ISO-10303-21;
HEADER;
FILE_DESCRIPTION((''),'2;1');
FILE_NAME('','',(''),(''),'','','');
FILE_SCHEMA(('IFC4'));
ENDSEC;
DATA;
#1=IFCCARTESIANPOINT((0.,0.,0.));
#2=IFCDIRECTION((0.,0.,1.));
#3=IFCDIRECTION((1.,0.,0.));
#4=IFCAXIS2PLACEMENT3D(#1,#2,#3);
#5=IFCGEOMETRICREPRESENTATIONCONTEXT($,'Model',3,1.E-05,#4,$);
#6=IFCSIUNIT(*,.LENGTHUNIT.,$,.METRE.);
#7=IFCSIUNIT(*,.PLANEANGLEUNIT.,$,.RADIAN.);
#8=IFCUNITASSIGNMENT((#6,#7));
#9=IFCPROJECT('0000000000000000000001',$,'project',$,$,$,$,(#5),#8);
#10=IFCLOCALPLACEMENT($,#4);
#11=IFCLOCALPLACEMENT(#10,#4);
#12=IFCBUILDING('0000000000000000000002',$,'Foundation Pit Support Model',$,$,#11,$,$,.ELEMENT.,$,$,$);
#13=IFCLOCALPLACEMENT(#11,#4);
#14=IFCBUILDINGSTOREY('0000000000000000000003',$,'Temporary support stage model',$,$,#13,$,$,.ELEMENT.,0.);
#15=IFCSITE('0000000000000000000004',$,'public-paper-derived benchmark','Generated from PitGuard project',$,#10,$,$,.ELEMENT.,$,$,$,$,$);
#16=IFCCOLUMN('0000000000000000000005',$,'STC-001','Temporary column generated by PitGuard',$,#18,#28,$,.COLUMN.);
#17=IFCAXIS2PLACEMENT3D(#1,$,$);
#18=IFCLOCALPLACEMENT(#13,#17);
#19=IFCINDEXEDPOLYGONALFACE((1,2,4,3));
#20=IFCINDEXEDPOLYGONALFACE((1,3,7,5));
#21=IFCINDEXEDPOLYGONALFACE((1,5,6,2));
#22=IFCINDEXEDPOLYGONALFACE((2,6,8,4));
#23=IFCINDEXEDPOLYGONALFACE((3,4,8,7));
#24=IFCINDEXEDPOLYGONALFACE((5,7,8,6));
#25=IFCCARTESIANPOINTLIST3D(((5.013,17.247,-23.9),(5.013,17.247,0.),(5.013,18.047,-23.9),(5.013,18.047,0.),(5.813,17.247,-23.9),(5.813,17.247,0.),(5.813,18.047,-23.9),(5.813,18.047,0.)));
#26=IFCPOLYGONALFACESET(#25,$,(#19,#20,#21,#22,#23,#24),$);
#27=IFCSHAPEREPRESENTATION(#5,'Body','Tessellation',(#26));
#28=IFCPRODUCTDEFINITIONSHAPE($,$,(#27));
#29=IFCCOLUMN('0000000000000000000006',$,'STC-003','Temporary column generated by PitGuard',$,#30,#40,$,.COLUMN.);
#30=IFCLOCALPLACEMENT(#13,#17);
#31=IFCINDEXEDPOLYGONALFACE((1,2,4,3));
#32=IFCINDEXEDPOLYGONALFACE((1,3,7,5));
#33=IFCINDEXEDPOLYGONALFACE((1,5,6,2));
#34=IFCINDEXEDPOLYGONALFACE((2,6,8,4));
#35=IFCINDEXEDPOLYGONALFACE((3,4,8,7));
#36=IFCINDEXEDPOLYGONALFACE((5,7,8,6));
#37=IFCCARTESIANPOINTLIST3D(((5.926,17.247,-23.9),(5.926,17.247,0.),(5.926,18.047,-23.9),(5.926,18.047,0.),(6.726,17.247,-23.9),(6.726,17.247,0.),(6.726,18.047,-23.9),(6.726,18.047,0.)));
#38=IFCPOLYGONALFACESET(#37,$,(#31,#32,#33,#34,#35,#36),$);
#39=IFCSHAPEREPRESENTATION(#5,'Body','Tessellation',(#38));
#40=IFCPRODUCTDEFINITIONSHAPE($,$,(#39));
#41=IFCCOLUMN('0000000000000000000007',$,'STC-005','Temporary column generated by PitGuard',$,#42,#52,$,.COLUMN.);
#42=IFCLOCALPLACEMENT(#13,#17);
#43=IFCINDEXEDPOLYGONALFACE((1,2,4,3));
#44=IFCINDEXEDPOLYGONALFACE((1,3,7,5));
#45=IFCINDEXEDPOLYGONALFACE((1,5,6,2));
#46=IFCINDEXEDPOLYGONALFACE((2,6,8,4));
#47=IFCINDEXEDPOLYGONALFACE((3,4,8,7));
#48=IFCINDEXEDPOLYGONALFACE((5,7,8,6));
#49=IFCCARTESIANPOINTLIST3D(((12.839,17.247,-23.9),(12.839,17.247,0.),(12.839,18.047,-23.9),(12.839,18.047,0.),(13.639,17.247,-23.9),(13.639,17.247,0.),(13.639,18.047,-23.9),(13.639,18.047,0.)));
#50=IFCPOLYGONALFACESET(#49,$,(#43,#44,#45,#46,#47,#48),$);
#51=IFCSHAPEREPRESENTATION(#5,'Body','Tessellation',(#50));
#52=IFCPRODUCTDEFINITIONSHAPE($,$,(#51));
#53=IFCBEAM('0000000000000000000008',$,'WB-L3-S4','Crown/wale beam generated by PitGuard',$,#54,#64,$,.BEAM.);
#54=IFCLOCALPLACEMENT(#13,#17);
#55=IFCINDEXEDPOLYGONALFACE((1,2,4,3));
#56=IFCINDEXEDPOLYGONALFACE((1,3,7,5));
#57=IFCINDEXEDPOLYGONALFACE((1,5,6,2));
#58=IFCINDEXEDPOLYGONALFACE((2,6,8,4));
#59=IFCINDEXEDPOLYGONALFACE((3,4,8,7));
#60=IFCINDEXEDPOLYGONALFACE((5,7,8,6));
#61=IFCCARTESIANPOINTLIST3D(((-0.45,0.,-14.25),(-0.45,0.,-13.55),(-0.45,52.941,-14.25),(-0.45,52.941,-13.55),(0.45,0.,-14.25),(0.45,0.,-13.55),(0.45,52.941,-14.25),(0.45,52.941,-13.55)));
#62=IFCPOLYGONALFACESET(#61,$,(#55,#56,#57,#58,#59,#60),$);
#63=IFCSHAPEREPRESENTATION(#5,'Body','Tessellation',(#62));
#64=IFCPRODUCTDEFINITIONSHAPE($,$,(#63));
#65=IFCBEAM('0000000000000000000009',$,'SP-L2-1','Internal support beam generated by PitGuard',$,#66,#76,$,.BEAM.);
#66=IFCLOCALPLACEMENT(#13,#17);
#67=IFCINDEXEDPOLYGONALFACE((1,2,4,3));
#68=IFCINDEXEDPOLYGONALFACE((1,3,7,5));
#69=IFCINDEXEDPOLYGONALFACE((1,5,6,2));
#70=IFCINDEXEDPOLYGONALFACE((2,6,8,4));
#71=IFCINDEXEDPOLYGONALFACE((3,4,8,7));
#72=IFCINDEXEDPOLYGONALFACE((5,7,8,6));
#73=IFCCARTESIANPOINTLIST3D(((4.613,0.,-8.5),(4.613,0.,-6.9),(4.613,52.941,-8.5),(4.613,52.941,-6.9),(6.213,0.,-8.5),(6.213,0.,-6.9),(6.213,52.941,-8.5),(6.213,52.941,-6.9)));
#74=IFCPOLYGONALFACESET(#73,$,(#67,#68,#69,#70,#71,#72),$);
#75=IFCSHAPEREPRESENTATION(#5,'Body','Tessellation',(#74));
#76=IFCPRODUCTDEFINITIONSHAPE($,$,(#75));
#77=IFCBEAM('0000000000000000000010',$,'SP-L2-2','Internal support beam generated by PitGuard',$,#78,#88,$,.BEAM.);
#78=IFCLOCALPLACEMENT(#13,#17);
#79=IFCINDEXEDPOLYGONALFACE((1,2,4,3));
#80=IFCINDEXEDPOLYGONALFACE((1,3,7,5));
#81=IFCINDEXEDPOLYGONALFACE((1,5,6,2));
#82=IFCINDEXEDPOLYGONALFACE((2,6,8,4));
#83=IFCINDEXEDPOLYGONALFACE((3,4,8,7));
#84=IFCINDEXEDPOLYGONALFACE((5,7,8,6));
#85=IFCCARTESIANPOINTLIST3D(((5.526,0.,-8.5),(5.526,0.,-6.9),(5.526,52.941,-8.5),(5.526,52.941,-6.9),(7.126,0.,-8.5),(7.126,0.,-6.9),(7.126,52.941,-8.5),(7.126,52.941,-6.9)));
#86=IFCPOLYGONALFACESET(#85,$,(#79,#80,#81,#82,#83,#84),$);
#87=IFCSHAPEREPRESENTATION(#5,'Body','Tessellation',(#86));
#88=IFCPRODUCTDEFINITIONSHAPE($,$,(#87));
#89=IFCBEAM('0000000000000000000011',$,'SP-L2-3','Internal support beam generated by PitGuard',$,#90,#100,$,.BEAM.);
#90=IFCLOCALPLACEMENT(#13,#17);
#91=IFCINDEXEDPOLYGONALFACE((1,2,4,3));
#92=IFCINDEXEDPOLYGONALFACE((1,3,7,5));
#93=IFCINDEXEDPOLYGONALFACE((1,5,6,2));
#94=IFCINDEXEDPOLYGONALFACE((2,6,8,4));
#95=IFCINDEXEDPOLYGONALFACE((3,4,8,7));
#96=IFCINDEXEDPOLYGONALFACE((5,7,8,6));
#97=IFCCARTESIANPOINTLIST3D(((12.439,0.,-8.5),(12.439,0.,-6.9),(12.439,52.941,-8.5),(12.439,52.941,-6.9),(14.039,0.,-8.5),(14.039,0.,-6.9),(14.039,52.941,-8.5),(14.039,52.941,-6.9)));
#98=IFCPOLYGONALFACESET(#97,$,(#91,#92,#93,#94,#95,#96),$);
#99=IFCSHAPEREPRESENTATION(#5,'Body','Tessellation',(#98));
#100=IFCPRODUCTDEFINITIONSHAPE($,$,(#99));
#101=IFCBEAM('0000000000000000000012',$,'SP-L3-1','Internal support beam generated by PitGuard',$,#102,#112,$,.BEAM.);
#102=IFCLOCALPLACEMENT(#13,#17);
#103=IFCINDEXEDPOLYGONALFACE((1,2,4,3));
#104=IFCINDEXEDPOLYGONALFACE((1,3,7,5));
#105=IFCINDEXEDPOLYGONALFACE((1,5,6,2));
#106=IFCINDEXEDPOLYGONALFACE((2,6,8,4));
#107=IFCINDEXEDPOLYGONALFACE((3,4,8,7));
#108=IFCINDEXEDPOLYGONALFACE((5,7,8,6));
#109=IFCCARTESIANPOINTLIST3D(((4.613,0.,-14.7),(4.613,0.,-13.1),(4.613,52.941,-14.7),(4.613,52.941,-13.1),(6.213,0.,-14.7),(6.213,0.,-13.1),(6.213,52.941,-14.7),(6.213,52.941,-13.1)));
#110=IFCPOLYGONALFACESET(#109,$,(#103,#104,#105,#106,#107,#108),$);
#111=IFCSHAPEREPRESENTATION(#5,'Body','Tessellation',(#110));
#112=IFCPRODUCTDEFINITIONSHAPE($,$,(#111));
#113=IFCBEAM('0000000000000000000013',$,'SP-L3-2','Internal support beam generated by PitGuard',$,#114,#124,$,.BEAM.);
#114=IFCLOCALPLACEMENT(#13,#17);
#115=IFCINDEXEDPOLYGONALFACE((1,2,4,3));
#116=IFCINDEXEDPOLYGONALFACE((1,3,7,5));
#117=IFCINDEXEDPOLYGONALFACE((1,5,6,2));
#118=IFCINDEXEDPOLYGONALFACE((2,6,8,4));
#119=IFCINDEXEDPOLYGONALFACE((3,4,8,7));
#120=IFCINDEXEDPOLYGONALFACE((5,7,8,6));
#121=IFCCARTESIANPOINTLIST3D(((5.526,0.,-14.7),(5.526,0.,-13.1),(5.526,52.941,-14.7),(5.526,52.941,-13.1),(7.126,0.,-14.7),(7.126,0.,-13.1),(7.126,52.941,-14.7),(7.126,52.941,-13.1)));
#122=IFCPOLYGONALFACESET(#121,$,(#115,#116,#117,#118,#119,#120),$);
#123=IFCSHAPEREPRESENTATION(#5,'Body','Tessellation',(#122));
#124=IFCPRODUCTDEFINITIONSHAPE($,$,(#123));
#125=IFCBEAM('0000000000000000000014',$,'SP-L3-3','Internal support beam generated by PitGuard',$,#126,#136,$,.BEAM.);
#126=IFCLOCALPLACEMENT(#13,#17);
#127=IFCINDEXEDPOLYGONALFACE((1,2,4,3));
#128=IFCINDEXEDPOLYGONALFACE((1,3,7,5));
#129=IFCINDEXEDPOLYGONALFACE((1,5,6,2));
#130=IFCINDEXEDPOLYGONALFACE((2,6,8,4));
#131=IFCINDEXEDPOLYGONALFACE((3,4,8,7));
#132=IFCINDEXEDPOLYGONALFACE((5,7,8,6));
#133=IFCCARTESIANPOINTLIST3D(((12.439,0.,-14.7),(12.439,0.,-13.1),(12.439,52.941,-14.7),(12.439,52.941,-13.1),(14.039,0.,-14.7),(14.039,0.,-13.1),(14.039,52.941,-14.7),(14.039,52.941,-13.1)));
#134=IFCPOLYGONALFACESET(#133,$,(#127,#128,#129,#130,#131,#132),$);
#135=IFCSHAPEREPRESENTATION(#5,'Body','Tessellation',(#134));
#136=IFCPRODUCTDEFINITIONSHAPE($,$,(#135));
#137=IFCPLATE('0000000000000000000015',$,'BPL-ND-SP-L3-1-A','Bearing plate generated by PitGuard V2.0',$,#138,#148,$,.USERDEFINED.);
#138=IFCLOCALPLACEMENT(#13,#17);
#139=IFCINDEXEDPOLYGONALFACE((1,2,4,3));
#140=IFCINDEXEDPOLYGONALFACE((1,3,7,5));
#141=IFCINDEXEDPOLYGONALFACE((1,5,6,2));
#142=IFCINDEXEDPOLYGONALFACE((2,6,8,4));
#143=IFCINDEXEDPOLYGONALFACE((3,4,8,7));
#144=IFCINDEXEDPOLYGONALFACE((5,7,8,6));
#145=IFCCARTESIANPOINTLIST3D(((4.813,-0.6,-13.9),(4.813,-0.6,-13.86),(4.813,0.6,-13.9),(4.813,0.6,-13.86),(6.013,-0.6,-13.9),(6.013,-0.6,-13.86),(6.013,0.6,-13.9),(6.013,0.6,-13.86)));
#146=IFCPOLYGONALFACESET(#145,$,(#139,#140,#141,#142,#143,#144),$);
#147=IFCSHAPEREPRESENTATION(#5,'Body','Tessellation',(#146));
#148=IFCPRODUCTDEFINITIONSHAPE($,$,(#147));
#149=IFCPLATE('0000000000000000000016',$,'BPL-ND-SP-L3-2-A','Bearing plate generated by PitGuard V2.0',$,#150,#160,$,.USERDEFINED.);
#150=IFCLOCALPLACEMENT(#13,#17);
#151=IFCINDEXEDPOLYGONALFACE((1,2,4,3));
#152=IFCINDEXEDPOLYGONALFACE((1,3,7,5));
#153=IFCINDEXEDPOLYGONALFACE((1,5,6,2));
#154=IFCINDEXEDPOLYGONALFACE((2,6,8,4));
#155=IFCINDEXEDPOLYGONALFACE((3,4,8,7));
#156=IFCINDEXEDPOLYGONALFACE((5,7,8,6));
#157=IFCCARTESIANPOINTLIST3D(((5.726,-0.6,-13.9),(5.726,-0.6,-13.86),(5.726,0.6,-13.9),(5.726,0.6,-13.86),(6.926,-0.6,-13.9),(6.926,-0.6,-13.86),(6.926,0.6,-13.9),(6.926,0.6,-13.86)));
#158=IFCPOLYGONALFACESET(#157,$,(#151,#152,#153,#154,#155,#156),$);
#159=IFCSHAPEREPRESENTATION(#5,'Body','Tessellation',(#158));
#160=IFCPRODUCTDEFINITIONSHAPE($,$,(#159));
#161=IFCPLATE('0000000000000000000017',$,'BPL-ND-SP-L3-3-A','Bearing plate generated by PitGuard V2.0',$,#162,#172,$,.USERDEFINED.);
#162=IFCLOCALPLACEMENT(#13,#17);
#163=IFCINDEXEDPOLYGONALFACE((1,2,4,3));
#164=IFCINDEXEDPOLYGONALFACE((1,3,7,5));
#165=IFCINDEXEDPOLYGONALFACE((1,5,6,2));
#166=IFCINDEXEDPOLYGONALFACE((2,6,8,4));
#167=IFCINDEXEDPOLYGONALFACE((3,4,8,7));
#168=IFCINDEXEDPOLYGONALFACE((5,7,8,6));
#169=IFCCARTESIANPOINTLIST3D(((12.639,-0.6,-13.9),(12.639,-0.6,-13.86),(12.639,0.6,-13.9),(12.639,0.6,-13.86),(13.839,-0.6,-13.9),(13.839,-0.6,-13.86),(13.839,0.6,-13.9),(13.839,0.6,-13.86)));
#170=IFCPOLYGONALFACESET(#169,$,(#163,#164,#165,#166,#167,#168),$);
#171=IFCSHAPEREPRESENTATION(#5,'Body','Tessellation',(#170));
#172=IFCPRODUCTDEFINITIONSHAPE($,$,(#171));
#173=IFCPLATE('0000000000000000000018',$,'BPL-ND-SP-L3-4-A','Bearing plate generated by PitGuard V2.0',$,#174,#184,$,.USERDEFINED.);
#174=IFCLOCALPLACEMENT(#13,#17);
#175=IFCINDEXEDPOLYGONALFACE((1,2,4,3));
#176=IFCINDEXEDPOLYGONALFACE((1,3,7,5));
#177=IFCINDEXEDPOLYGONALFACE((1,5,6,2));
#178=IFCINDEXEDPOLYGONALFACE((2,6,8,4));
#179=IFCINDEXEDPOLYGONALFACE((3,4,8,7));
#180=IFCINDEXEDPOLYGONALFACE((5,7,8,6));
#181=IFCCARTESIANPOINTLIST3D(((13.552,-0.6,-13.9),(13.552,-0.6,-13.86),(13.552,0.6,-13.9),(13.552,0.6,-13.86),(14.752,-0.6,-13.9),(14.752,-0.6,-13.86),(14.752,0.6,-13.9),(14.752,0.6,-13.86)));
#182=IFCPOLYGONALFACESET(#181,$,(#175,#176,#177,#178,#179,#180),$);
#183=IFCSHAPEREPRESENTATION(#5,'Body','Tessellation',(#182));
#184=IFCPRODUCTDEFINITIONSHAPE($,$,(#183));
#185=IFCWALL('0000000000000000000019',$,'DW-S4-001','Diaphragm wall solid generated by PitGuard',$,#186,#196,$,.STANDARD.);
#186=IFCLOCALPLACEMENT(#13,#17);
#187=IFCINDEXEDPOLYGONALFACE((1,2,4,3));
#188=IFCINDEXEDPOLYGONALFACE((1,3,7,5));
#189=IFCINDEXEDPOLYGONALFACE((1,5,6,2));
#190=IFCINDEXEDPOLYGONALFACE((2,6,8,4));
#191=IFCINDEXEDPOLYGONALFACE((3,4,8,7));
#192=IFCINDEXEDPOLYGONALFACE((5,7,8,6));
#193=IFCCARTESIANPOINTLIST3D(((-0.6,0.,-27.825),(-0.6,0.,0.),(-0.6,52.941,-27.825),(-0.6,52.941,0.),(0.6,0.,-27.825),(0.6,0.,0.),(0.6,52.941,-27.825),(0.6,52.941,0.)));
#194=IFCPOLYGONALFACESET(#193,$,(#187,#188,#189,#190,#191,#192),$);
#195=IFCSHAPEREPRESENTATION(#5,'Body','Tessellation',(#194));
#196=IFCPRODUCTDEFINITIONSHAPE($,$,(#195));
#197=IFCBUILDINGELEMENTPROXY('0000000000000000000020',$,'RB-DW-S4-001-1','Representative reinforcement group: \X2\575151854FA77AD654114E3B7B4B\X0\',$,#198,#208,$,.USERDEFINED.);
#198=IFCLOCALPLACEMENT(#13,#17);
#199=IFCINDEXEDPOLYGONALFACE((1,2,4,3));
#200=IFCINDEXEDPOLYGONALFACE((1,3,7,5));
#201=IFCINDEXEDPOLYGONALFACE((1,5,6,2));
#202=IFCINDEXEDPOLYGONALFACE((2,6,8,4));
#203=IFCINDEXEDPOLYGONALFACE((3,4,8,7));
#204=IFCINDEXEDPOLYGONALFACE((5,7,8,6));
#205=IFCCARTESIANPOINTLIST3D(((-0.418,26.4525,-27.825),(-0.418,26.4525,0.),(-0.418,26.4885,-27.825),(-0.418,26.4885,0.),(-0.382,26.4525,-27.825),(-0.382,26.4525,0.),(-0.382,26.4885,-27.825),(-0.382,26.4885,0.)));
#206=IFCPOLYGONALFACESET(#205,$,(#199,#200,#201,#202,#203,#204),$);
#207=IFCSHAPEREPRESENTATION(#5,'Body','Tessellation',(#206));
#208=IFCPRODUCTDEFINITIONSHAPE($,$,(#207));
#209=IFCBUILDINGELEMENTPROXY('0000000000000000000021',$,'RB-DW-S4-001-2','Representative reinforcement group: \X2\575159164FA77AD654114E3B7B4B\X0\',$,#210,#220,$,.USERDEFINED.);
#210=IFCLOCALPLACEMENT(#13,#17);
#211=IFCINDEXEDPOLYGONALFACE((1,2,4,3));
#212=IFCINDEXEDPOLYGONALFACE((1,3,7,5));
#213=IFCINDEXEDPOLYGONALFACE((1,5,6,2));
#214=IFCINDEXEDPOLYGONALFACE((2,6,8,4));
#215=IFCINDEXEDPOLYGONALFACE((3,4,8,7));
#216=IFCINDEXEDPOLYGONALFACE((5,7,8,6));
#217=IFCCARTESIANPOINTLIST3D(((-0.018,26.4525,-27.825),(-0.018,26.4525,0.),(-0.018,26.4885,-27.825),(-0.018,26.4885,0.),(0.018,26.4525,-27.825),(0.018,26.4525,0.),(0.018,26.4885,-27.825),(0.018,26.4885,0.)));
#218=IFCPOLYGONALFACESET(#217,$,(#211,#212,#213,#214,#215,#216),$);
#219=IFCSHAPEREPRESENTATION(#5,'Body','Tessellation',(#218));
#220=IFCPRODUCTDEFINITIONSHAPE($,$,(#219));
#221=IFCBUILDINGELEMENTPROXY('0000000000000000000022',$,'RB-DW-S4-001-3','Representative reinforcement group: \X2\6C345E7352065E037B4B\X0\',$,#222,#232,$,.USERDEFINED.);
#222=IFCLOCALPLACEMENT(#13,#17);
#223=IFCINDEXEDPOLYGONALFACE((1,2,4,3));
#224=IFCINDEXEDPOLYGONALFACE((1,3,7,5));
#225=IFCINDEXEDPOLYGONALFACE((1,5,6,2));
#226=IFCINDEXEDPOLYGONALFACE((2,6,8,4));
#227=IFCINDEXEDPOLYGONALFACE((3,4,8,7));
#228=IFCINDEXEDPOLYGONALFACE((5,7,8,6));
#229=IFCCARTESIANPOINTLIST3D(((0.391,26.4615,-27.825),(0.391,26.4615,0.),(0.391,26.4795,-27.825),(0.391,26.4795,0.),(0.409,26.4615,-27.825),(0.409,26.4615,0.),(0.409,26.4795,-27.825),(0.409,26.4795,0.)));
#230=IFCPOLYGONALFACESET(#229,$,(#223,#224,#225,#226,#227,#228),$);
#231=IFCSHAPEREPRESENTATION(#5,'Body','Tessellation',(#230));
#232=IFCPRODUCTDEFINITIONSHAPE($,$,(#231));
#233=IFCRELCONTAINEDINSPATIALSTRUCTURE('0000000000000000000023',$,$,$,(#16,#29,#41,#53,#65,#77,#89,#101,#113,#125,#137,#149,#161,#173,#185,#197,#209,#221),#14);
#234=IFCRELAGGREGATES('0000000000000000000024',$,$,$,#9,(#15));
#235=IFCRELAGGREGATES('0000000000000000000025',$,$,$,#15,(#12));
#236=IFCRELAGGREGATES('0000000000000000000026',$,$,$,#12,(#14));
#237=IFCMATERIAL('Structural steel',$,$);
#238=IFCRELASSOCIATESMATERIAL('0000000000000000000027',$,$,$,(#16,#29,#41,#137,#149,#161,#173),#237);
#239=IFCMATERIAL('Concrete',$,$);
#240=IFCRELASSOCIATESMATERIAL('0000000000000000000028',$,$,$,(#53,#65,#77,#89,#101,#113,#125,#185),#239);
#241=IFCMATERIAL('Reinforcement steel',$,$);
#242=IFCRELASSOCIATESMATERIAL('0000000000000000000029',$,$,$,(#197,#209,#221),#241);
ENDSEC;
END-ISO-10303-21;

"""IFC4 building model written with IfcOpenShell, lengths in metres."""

from ifc_helpers import new_model, si_unit, frame, origin_with_axes, origin_2d, place, context, project, spatial, rectangle, extrude, material, element, save


model = new_model("IFC4")

# Units and contexts
model_context = context("Model", 3, precision=1e-05, world=origin_with_axes())
ifc_project = project(units=[si_unit("LENGTHUNIT", "METRE"), si_unit("PLANEANGLEUNIT", "RADIAN")], contexts=[model_context])

# Site, building, storey
site_placement = place(None, origin_with_axes())
site = spatial("IfcSite", under=ifc_project, at=site_placement, Name="public-paper-derived benchmark", Description="Generated from PitGuard project", CompositionType="ELEMENT")
building_placement = place(site_placement, origin_with_axes())
building = spatial("IfcBuilding", under=site, at=building_placement, Name="Foundation Pit Support Model", CompositionType="ELEMENT")
storey_placement = place(building_placement, origin_with_axes())
storey = spatial("IfcBuildingStorey", under=building, at=storey_placement, Name="Temporary support stage model", CompositionType="ELEMENT", Elevation=0.0)

# Columns
ifc_material_1 = material(Name="Structural steel")
for number, where, z_axis, x_axis, name in (
    (1, (5.413, 17.647, -23.9), (0.0, 0.0, 1.0), (1.0, 0.0, 0.0), "STC-001"),
    (2, (6.326, 17.647, -23.9), (0.0, 0.0, 1.0), (1.0, 0.0, 0.0), "STC-003"),
    (3, (13.239, 17.647, -23.9), (0.0, 0.0, 1.0), (1.0, 0.0, 0.0), "STC-005"),
):
    element("IfcColumn", number, at=place(storey_placement, frame(where, z_axis=z_axis, x_axis=x_axis)), inside=storey, material=ifc_material_1, Name=name, Description="Temporary column generated by PitGuard", PredefinedType="COLUMN", context=model_context, shape_type="SweptSolid", body=[
        extrude(rectangle(XDim=0.8, YDim=0.8, at=origin_2d()), origin_with_axes(), (0.0, 0.0, 1.0), 23.9),
    ])

# Beams
ifc_material_2 = material(Name="Concrete")
beam_placement = place(storey_placement, frame((0.0, 26.4705, -14.25), z_axis=(0.0, 0.0, 1.0), x_axis=(0.0, -1.0, 0.0)))
element("IfcBeam", 4, at=beam_placement, inside=storey, material=ifc_material_2, Name="WB-L3-S4", Description="Crown/wale beam generated by PitGuard", PredefinedType="BEAM", context=model_context, shape_type="SweptSolid", body=[
    extrude(rectangle(XDim=52.941, YDim=0.9, at=origin_2d()), origin_with_axes(), (0.0, 0.0, 1.0), 0.7),
])
for number, where, z_axis, x_axis, name in (
    (5, (5.413, 26.4705, -8.5), (0.0, 0.0, 1.0), (0.0, 1.0, 0.0), "SP-L2-1"),
    (6, (6.326, 26.4705, -8.5), (0.0, 0.0, 1.0), (0.0, 1.0, 0.0), "SP-L2-2"),
    (7, (13.239, 26.4705, -8.5), (0.0, 0.0, 1.0), (0.0, 1.0, 0.0), "SP-L2-3"),
    (8, (5.413, 26.4705, -14.7), (0.0, 0.0, 1.0), (0.0, 1.0, 0.0), "SP-L3-1"),
    (9, (6.326, 26.4705, -14.7), (0.0, 0.0, 1.0), (0.0, 1.0, 0.0), "SP-L3-2"),
    (10, (13.239, 26.4705, -14.7), (0.0, 0.0, 1.0), (0.0, 1.0, 0.0), "SP-L3-3"),
):
    element("IfcBeam", number, at=place(storey_placement, frame(where, z_axis=z_axis, x_axis=x_axis)), inside=storey, material=ifc_material_2, Name=name, Description="Internal support beam generated by PitGuard", PredefinedType="BEAM", context=model_context, shape_type="SweptSolid", body=[
        extrude(rectangle(XDim=52.941, YDim=1.6, at=origin_2d()), origin_with_axes(), (0.0, 0.0, 1.0), 1.6),
    ])

# Plates
for number, where, z_axis, x_axis, name in (
    (11, (5.413, 0.0, -13.9), (0.0, 0.0, 1.0), (1.0, 0.0, 0.0), "BPL-ND-SP-L3-1-A"),
    (12, (6.326, 0.0, -13.9), (0.0, 0.0, 1.0), (1.0, 0.0, 0.0), "BPL-ND-SP-L3-2-A"),
    (13, (13.239, 0.0, -13.9), (0.0, 0.0, 1.0), (1.0, 0.0, 0.0), "BPL-ND-SP-L3-3-A"),
    (14, (14.152, 0.0, -13.9), (0.0, 0.0, 1.0), (1.0, 0.0, 0.0), "BPL-ND-SP-L3-4-A"),
):
    element("IfcPlate", number, at=place(storey_placement, frame(where, z_axis=z_axis, x_axis=x_axis)), inside=storey, material=ifc_material_1, Name=name, Description="Bearing plate generated by PitGuard V2.0", PredefinedType="USERDEFINED", context=model_context, shape_type="SweptSolid", body=[
        extrude(rectangle(XDim=1.2, YDim=1.2, at=origin_2d()), origin_with_axes(), (0.0, 0.0, 1.0), 0.04),
    ])

# Wall
wall_placement = place(storey_placement, frame((0.0, 26.4705, -27.825), z_axis=(0.0, 0.0, 1.0), x_axis=(0.0, -1.0, 0.0)))
element("IfcWall", 15, at=wall_placement, inside=storey, material=ifc_material_2, Name="DW-S4-001", Description="Diaphragm wall solid generated by PitGuard", PredefinedType="STANDARD", context=model_context, shape_type="SweptSolid", body=[
    extrude(rectangle(XDim=52.941, YDim=1.2, at=origin_2d()), origin_with_axes(), (0.0, 0.0, 1.0), 27.825),
])

# Building element proxies
ifc_material_3 = material(Name="Reinforcement steel")
for number, where, z_axis, x_axis, name, description in (
    (16, (-0.4, 26.4705, -27.825), (0.0, 0.0, 1.0), (1.0, 0.0, 0.0), "RB-DW-S4-001-1", "Representative reinforcement group: 坑内侧竖向主筋"),
    (17, (0.0, 26.4705, -27.825), (0.0, 0.0, 1.0), (1.0, 0.0, 0.0), "RB-DW-S4-001-2", "Representative reinforcement group: 坑外侧竖向主筋"),
):
    element("IfcBuildingElementProxy", number, at=place(storey_placement, frame(where, z_axis=z_axis, x_axis=x_axis)), inside=storey, material=ifc_material_3, Name=name, Description=description, PredefinedType="USERDEFINED", context=model_context, shape_type="SweptSolid", body=[
        extrude(rectangle(XDim=0.036, YDim=0.036, at=origin_2d()), origin_with_axes(), (0.0, 0.0, 1.0), 27.825),
    ])
proxy_1_placement = place(storey_placement, frame((0.4, 26.4705, -27.825), z_axis=(0.0, 0.0, 1.0), x_axis=(1.0, 0.0, 0.0)))
element("IfcBuildingElementProxy", 18, at=proxy_1_placement, inside=storey, material=ifc_material_3, Name="RB-DW-S4-001-3", Description="Representative reinforcement group: 水平分布筋", PredefinedType="USERDEFINED", context=model_context, shape_type="SweptSolid", body=[
    extrude(rectangle(XDim=0.018, YDim=0.018, at=origin_2d()), origin_with_axes(), (0.0, 0.0, 1.0), 27.825),
])

save(model, "model.ifc")
